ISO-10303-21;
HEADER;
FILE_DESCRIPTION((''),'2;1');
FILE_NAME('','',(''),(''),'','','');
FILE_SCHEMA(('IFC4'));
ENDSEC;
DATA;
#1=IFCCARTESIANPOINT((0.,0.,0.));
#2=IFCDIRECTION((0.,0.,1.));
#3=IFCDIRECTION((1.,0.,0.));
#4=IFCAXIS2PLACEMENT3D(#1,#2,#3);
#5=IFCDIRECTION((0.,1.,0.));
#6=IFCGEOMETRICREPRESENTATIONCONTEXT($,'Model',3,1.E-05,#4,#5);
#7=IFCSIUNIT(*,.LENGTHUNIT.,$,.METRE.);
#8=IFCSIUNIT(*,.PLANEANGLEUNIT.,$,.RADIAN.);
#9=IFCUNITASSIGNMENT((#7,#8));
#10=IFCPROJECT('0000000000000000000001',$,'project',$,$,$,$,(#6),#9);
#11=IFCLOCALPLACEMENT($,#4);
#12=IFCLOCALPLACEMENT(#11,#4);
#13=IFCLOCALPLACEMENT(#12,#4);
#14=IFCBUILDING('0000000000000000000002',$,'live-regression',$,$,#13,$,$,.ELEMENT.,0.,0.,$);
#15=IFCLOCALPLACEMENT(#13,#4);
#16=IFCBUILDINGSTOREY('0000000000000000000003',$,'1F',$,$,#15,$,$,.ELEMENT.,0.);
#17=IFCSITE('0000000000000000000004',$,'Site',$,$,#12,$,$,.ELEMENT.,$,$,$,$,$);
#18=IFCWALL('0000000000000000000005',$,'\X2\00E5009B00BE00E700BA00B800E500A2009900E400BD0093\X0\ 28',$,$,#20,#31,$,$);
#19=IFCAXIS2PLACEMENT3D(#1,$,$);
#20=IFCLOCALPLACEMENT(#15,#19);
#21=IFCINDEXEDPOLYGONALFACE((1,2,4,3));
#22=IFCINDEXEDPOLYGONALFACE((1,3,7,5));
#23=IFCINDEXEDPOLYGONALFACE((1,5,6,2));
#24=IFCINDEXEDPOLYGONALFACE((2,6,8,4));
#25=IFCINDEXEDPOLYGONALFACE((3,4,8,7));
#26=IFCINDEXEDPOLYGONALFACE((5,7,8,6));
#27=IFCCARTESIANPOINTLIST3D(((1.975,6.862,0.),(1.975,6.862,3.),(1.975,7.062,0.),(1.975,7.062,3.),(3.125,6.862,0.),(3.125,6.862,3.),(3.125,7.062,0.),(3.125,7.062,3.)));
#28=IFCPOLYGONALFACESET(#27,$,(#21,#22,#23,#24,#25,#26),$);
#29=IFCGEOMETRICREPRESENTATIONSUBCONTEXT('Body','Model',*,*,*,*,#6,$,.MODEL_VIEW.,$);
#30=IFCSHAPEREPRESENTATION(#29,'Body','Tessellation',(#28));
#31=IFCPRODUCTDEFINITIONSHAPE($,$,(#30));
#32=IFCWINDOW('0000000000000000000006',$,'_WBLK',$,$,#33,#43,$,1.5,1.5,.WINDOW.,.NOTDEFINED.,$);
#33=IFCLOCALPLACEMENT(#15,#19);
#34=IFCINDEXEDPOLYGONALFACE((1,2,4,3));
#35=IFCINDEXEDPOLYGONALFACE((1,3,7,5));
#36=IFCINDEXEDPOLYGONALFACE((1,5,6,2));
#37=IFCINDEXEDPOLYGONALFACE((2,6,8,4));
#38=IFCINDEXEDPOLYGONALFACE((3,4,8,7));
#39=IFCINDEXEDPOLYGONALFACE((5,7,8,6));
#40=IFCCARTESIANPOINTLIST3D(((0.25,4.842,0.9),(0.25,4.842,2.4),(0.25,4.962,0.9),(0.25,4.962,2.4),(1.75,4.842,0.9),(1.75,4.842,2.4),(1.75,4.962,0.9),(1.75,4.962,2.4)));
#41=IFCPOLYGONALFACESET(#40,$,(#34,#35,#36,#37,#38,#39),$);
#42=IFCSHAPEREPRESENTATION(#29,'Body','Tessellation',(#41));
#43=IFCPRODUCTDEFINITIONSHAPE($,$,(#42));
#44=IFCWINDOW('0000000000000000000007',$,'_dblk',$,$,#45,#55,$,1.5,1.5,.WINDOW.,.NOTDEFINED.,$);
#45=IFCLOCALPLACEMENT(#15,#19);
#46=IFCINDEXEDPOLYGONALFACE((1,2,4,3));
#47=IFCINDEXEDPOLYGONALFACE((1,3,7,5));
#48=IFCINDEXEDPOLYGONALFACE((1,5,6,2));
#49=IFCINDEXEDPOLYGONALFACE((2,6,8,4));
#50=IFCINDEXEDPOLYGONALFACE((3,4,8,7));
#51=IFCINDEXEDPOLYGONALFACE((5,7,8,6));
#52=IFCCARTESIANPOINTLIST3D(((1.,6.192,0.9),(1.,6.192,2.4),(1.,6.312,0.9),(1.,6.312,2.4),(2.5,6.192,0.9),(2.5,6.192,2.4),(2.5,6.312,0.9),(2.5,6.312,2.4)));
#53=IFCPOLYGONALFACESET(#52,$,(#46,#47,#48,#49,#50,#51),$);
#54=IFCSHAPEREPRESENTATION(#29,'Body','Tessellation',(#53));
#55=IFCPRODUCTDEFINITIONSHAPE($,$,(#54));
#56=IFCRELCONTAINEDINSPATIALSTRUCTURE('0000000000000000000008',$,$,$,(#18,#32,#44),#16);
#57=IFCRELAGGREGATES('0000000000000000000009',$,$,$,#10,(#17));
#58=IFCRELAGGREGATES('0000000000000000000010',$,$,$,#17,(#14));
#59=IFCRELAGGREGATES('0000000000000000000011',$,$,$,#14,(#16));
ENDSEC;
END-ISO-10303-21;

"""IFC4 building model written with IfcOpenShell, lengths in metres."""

from ifc_helpers import new_model, si_unit, direction, frame, frame_2d, origin_with_axes, place, context, subcontext, project, spatial, rectangle, extrude, element, save


model = new_model("IFC4")

# Units and contexts
model_context = context("Model", 3, precision=1e-05, world=origin_with_axes(), true_north=direction((0.0, 1.0, 0.0)))
body_context = subcontext(model_context, "Body", "Model", "MODEL_VIEW")
ifc_project = project(units=[si_unit("LENGTHUNIT", "METRE"), si_unit("PLANEANGLEUNIT", "RADIAN")], contexts=[model_context])

# Site, building, storey
placement = place(None, origin_with_axes())
site_placement = place(placement, origin_with_axes())
site = spatial("IfcSite", under=ifc_project, at=site_placement, Name="Site", CompositionType="ELEMENT")
building_placement = place(site_placement, origin_with_axes())
building = spatial("IfcBuilding", under=site, at=building_placement, Name="live-regression", CompositionType="ELEMENT", ElevationOfRefHeight=0.0, ElevationOfTerrain=0.0)
storey_placement = place(building_placement, origin_with_axes())
storey = spatial("IfcBuildingStorey", under=building, at=storey_placement, Name="1F", CompositionType="ELEMENT", Elevation=0.0)

# Wall
wall_1_placement = place(storey_placement, frame((2.55, 6.962, 0.0), z_axis=(0.0, 0.0, 1.0), x_axis=(-1.0, 0.0, 0.0)))
element("IfcWall", 1, at=wall_1_placement, inside=storey, Name="å\u009b¾çº¸å¢\u0099ä½\u0093 28", context=body_context, shape_type="SweptSolid", body=[
    extrude(rectangle(XDim=1.15, YDim=0.2, at=frame_2d((0.0, 0.0), x_axis=(1.0, 0.0, 0.0))), frame((0.0, 0.0, 0.0), z_axis=(0.0, 0.0, 1.0)), (0.0, 0.0, 1.0), 3.0),
])

# Windows
for number, where, z_axis, x_axis, name in (
    (2, (1.0, 4.902, 0.9), (0.0, 0.0, 1.0), (1.0, 0.0, 0.0), "_WBLK"),
    (3, (1.75, 6.252, 0.9), (0.0, 0.0, 1.0), (1.0, 0.0, 0.0), "_dblk"),
):
    element("IfcWindow", number, at=place(storey_placement, frame(where, z_axis=z_axis, x_axis=x_axis)), inside=storey, Name=name, OverallHeight=1.5, OverallWidth=1.5, PartitioningType="NOTDEFINED", PredefinedType="WINDOW", context=body_context, shape_type="SweptSolid", body=[
        extrude(rectangle(XDim=1.5, YDim=0.12, at=frame_2d((0.0, 0.0), x_axis=(1.0, 0.0, 0.0))), frame((0.0, 0.0, 0.0), z_axis=(0.0, 0.0, 1.0)), (0.0, 0.0, 1.0), 1.5),
    ])

save(model, "model.ifc")
